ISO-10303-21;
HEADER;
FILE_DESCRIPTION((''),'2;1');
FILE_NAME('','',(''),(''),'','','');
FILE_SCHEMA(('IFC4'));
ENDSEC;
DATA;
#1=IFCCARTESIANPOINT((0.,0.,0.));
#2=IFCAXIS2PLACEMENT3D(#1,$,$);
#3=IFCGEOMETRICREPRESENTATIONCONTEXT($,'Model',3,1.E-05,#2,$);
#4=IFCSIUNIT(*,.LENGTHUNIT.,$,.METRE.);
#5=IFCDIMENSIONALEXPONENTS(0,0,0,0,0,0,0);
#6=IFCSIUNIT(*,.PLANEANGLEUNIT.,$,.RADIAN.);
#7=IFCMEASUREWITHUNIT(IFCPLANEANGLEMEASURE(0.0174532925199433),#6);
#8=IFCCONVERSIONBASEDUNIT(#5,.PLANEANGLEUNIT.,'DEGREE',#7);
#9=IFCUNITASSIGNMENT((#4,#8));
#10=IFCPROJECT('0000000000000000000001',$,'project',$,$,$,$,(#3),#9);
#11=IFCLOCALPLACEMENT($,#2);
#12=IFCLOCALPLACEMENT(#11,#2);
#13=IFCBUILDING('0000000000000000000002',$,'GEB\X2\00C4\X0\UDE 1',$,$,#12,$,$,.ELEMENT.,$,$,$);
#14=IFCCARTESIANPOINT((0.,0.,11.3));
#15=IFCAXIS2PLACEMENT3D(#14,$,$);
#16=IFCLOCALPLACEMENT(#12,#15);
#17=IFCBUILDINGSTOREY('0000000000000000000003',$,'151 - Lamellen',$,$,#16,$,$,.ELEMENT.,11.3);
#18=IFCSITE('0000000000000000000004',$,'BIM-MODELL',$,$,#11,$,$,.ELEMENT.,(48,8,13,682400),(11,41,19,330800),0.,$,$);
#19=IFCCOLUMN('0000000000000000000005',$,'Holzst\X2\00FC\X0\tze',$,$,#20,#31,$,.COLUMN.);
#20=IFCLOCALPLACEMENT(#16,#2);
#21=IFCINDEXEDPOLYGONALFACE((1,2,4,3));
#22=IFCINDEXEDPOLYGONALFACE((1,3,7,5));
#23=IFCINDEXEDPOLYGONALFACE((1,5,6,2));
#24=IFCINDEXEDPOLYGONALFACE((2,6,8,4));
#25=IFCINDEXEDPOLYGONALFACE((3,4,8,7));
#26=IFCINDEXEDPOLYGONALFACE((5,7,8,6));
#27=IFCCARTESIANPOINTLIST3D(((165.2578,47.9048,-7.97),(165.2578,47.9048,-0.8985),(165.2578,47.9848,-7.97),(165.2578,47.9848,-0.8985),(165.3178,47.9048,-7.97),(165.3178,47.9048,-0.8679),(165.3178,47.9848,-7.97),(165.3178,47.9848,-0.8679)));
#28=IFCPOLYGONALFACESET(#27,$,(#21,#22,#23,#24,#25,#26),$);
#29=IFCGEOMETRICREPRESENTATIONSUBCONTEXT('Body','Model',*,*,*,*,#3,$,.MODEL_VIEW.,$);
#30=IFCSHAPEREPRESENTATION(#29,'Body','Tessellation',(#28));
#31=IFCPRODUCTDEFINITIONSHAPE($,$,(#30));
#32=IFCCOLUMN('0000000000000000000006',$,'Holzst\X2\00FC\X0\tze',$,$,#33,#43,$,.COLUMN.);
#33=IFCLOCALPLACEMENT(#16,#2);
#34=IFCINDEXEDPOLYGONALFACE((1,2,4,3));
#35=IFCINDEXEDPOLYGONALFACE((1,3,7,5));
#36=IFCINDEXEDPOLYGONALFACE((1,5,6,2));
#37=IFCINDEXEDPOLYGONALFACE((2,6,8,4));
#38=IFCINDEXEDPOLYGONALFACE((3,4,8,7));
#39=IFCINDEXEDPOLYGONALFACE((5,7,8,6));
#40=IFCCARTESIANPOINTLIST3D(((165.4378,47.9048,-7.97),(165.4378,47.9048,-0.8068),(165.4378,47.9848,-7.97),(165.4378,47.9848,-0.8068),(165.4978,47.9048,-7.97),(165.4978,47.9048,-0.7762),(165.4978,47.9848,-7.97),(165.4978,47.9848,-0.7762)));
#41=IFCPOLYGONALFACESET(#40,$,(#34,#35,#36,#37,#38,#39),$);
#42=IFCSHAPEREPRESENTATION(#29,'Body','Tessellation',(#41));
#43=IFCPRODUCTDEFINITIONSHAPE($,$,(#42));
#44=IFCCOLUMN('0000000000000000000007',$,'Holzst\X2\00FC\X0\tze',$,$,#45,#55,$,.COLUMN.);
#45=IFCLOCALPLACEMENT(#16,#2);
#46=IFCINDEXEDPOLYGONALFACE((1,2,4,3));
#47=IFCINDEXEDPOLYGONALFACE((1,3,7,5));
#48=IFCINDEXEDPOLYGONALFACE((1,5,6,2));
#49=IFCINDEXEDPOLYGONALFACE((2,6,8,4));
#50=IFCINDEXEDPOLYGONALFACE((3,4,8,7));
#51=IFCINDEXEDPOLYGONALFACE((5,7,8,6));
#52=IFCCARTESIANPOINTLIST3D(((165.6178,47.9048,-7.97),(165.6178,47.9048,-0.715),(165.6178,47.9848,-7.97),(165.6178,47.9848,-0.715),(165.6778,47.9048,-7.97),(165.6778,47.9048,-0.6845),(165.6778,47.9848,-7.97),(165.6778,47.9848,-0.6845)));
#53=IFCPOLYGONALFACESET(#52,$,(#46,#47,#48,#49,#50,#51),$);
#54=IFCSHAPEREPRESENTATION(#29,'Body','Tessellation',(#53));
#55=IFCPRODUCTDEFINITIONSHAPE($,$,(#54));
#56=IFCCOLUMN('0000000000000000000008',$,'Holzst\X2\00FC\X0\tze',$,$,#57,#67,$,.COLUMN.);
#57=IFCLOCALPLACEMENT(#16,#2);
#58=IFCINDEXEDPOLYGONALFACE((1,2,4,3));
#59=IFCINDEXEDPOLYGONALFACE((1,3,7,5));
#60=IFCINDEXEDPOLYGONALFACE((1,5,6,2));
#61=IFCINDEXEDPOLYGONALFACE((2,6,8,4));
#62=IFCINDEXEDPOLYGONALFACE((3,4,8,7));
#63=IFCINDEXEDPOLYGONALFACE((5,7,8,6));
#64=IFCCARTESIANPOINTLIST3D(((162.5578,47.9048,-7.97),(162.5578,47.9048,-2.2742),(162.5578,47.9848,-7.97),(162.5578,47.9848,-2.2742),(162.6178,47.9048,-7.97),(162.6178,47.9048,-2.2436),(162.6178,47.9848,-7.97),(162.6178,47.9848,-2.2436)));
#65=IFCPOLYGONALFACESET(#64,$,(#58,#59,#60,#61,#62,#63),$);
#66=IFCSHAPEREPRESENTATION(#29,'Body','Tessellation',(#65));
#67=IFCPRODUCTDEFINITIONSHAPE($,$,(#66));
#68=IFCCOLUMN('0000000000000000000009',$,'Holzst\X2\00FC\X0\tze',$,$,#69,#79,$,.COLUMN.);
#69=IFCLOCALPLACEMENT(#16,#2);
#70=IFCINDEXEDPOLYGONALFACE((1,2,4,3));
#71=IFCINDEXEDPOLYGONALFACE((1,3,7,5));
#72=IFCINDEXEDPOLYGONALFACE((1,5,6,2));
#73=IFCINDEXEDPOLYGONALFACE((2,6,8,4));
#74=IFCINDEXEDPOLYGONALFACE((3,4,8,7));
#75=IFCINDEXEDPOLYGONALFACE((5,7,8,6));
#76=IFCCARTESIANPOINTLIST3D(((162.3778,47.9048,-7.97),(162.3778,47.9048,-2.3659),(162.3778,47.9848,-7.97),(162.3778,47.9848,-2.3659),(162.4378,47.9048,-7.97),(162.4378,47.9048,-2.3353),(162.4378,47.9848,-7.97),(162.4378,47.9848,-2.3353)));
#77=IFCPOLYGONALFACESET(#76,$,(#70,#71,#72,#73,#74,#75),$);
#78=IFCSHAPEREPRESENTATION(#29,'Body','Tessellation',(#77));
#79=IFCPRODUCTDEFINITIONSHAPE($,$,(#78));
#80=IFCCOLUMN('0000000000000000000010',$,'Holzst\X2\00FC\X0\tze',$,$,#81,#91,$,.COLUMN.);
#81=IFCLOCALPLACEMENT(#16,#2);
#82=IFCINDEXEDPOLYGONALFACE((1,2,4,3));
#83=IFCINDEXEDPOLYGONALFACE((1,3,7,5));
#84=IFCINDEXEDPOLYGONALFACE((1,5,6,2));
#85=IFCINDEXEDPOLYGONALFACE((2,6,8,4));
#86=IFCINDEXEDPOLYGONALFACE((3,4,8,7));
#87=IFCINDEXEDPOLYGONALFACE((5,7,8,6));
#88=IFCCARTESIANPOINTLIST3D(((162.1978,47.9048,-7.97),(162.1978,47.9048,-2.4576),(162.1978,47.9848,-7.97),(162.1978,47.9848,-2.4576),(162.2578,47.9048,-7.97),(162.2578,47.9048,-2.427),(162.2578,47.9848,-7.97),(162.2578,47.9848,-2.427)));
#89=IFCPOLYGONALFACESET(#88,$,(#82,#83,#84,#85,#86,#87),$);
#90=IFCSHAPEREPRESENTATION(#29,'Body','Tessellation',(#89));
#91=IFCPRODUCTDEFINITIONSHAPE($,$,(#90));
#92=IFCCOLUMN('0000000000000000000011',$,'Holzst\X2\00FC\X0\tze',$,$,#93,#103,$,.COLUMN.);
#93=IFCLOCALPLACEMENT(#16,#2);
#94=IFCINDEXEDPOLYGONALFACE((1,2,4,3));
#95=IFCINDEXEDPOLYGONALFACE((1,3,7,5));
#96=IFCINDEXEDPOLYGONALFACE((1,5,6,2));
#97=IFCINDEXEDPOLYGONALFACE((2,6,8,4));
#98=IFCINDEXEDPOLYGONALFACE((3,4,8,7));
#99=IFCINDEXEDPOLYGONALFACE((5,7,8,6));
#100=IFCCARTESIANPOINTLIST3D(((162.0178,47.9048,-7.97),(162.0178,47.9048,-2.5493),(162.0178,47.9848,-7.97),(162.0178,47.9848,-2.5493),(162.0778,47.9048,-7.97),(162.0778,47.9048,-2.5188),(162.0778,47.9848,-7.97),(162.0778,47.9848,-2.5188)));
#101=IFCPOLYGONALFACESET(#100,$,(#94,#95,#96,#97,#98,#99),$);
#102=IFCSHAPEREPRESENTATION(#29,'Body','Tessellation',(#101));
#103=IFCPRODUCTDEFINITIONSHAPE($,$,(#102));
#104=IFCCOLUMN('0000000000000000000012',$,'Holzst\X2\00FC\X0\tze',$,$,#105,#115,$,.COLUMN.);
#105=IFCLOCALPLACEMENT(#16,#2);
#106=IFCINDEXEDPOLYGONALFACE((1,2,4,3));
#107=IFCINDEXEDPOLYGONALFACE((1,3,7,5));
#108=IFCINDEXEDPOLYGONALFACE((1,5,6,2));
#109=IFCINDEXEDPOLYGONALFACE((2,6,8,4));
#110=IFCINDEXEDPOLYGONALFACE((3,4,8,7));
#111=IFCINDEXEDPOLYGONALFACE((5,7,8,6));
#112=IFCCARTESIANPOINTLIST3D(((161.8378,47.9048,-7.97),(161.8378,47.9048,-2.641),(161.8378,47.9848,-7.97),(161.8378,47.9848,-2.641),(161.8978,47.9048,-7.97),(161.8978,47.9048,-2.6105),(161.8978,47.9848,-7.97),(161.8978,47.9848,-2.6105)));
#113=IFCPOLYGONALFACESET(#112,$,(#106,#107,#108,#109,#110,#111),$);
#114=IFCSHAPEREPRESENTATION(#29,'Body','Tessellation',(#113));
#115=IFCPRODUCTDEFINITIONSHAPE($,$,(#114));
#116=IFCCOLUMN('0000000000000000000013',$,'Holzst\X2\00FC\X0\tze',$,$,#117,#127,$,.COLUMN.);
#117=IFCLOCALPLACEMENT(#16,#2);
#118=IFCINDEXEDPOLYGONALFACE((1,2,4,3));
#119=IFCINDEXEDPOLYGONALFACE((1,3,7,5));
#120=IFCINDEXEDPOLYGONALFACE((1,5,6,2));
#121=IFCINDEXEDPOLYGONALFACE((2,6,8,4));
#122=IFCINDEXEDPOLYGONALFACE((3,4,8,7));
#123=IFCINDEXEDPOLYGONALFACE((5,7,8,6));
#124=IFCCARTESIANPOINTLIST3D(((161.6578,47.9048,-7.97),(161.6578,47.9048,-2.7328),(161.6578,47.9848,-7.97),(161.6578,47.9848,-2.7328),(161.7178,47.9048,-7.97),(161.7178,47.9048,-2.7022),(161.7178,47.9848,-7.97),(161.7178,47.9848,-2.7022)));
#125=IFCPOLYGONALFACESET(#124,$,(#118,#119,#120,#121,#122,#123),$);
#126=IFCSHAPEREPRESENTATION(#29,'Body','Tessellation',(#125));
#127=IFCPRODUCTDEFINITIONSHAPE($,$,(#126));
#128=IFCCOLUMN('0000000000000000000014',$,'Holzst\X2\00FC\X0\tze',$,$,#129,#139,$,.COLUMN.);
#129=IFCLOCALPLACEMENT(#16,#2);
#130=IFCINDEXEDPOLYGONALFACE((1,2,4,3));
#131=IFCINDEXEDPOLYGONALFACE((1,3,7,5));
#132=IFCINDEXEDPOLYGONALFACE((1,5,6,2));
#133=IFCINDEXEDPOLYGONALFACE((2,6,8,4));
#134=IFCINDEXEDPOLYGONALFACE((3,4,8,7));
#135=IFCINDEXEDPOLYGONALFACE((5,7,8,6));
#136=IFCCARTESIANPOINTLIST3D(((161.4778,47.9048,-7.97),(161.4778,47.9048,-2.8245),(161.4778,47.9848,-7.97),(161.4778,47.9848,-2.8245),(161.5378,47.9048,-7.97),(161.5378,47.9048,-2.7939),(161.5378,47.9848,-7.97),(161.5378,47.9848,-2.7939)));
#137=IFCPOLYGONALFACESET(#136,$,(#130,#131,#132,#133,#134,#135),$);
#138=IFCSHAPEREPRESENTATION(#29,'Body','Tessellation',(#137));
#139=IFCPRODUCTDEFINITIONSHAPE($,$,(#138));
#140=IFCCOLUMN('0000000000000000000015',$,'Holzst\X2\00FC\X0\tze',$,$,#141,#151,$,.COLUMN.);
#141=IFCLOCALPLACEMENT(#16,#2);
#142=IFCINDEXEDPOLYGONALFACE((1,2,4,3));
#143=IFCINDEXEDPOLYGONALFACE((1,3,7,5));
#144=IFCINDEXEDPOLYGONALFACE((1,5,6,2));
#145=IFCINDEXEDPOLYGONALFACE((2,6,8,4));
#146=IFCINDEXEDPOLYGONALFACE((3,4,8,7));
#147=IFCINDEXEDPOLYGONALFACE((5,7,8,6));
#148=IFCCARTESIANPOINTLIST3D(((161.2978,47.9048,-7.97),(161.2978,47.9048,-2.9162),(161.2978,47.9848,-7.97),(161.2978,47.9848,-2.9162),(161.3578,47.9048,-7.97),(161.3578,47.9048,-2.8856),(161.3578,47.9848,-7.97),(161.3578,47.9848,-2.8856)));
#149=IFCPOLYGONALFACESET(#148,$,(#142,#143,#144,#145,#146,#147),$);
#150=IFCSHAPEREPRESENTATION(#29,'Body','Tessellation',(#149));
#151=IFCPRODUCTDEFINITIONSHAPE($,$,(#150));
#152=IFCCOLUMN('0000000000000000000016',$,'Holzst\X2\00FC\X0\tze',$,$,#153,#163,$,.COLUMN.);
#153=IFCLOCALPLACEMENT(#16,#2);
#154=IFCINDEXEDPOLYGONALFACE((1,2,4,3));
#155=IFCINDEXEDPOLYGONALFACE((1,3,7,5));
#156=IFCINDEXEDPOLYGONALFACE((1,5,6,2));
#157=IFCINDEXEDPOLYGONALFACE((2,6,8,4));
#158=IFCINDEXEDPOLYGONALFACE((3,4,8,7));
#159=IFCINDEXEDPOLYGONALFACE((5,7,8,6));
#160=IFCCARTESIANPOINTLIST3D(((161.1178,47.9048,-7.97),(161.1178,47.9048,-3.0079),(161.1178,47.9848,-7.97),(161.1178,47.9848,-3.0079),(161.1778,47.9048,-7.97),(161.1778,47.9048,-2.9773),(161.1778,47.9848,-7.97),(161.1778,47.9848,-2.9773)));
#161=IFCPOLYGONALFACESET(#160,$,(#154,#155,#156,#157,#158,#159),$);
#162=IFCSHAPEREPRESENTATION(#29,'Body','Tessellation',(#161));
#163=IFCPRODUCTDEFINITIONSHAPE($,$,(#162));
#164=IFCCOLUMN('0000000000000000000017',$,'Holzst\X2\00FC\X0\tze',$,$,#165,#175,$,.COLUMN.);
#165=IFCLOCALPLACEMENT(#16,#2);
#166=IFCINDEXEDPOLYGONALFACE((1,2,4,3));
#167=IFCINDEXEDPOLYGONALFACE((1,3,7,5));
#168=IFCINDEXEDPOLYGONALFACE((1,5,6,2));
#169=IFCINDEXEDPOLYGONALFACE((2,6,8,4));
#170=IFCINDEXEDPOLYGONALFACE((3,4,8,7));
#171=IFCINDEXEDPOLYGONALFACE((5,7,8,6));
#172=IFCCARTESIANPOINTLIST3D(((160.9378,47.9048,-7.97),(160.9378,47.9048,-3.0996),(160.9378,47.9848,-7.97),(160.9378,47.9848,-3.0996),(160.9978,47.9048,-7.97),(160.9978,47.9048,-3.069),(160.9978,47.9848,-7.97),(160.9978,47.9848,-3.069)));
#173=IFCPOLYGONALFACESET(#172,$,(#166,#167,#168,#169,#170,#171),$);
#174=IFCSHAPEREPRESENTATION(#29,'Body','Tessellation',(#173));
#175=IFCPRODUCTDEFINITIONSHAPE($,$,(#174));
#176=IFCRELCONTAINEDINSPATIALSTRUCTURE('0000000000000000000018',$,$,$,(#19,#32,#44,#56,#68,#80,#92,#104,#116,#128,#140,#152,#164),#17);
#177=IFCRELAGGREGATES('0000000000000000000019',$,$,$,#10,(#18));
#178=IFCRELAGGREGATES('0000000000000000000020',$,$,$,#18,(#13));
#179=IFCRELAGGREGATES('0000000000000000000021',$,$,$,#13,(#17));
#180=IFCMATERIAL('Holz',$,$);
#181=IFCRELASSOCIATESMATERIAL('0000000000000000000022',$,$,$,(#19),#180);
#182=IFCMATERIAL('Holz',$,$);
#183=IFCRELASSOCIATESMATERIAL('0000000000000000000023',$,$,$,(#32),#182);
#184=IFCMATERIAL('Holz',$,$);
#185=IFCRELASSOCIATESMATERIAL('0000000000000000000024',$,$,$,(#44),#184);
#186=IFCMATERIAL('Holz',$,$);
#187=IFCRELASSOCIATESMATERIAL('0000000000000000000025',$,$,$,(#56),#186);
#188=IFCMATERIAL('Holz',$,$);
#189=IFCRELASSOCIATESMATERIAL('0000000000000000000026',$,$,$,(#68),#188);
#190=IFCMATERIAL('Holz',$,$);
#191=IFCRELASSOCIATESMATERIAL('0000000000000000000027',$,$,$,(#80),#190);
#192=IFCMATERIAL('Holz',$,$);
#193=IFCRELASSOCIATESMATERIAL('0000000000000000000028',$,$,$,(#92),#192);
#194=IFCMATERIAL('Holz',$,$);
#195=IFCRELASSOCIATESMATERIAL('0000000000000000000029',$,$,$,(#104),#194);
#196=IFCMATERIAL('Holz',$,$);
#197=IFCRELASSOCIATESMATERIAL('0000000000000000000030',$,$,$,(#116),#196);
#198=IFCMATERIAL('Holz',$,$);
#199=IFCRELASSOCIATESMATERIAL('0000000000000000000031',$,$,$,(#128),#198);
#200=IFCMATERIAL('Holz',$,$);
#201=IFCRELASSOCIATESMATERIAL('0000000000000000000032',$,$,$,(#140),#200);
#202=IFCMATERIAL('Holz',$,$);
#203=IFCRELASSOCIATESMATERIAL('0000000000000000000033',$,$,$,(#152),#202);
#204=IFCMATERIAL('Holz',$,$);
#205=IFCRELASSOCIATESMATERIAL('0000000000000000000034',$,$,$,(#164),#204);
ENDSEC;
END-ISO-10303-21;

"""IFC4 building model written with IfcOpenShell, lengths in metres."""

from ifc_helpers import new_model, entity, si_unit, converted_unit, frame, frame_2d, origin, origin_with_axes, place, context, subcontext, project, spatial, rectangle, extrude, clip, halfspace, material, element, save


model = new_model("IFC4")

# Units and contexts
model_context = context("Model", 3, precision=1e-05, world=origin())
body_context = subcontext(model_context, "Body", "Model", "MODEL_VIEW")
ifc_project = project(units=[si_unit("LENGTHUNIT", "METRE"), converted_unit("PLANEANGLEUNIT", "DEGREE", entity("IfcPlaneAngleMeasure", 0.0174532925199433), si_unit("PLANEANGLEUNIT", "RADIAN"), dimensions=[0, 0, 0, 0, 0, 0, 0])], contexts=[model_context])

# Site, building, storey
site_placement = place(None, origin())
site = spatial("IfcSite", under=ifc_project, at=site_placement, Name="BIM-MODELL", CompositionType="ELEMENT", RefLatitude=(48, 8, 13, 682400), RefLongitude=(11, 41, 19, 330800), RefElevation=0.0)
building_placement = place(site_placement, origin())
building = spatial("IfcBuilding", under=site, at=building_placement, Name="GEBÄUDE 1", CompositionType="ELEMENT")
storey_placement = place(building_placement, frame((0.0, 0.0, 11.3)))
storey = spatial("IfcBuildingStorey", under=building, at=storey_placement, Name="151 - Lamellen", CompositionType="ELEMENT", Elevation=11.3)

# Columns
ifc_material_1 = material(Name="Holz")
column_1_placement = place(storey_placement, frame((165.2578, 47.9048, -7.97)))
element("IfcColumn", 1, at=column_1_placement, inside=storey, material=ifc_material_1, Name="Holzstütze", PredefinedType="COLUMN", context=body_context, shape_type="Clipping", body=[
    clip(extrude(rectangle(XDim=0.06, YDim=0.08, at=frame_2d((0.03, 0.04), x_axis=(1.0, 0.0))), origin_with_axes(), (0.0, 0.0, 1.0), 7.1021), halfspace(frame((0.03, 0.04, 7.0868), z_axis=(0.45399, 0.0, -0.891007), x_axis=(0.0, 1.0, 0.0)), True)),
])
ifc_material_2 = material(Name="Holz")
column_2_placement = place(storey_placement, frame((165.4378, 47.9048, -7.97)))
element("IfcColumn", 2, at=column_2_placement, inside=storey, material=ifc_material_2, Name="Holzstütze", PredefinedType="COLUMN", context=body_context, shape_type="Clipping", body=[
    clip(extrude(rectangle(XDim=0.06, YDim=0.08, at=frame_2d((0.03, 0.04), x_axis=(1.0, 0.0))), origin_with_axes(), (0.0, 0.0, 1.0), 7.1938), halfspace(frame((0.03, 0.04, 7.1785), z_axis=(0.45399, 0.0, -0.891007), x_axis=(0.0, 1.0, 0.0)), True)),
])
ifc_material_3 = material(Name="Holz")
column_3_placement = place(storey_placement, frame((165.6178, 47.9048, -7.97)))
element("IfcColumn", 3, at=column_3_placement, inside=storey, material=ifc_material_3, Name="Holzstütze", PredefinedType="COLUMN", context=body_context, shape_type="Clipping", body=[
    clip(extrude(rectangle(XDim=0.06, YDim=0.08, at=frame_2d((0.03, 0.04), x_axis=(1.0, 0.0))), origin_with_axes(), (0.0, 0.0, 1.0), 7.2855), halfspace(frame((0.03, 0.04, 7.2702), z_axis=(0.45399, 0.0, -0.891007), x_axis=(0.0, 1.0, 0.0)), True)),
])
ifc_material_4 = material(Name="Holz")
column_4_placement = place(storey_placement, frame((162.5578, 47.9048, -7.97)))
element("IfcColumn", 4, at=column_4_placement, inside=storey, material=ifc_material_4, Name="Holzstütze", PredefinedType="COLUMN", context=body_context, shape_type="Clipping", body=[
    clip(extrude(rectangle(XDim=0.06, YDim=0.08, at=frame_2d((0.03, 0.04), x_axis=(1.0, 0.0))), origin_with_axes(), (0.0, 0.0, 1.0), 5.7264), halfspace(frame((0.03, 0.04, 5.7111), z_axis=(0.45399, 0.0, -0.891007), x_axis=(0.0, 1.0, 0.0)), True)),
])
ifc_material_5 = material(Name="Holz")
column_5_placement = place(storey_placement, frame((162.3778, 47.9048, -7.97)))
element("IfcColumn", 5, at=column_5_placement, inside=storey, material=ifc_material_5, Name="Holzstütze", PredefinedType="COLUMN", context=body_context, shape_type="Clipping", body=[
    clip(extrude(rectangle(XDim=0.06, YDim=0.08, at=frame_2d((0.03, 0.04), x_axis=(1.0, 0.0))), origin_with_axes(), (0.0, 0.0, 1.0), 5.6347), halfspace(frame((0.03, 0.04, 5.6194), z_axis=(0.45399, 0.0, -0.891007), x_axis=(0.0, 1.0, 0.0)), True)),
])
ifc_material_6 = material(Name="Holz")
column_6_placement = place(storey_placement, frame((162.1978, 47.9048, -7.97)))
element("IfcColumn", 6, at=column_6_placement, inside=storey, material=ifc_material_6, Name="Holzstütze", PredefinedType="COLUMN", context=body_context, shape_type="Clipping", body=[
    clip(extrude(rectangle(XDim=0.06, YDim=0.08, at=frame_2d((0.03, 0.04), x_axis=(1.0, 0.0))), origin_with_axes(), (0.0, 0.0, 1.0), 5.543), halfspace(frame((0.03, 0.04, 5.5277), z_axis=(0.45399, 0.0, -0.891007), x_axis=(0.0, 1.0, 0.0)), True)),
])
ifc_material_7 = material(Name="Holz")
column_7_placement = place(storey_placement, frame((162.0178, 47.9048, -7.97)))
element("IfcColumn", 7, at=column_7_placement, inside=storey, material=ifc_material_7, Name="Holzstütze", PredefinedType="COLUMN", context=body_context, shape_type="Clipping", body=[
    clip(extrude(rectangle(XDim=0.06, YDim=0.08, at=frame_2d((0.03, 0.04), x_axis=(1.0, 0.0))), origin_with_axes(), (0.0, 0.0, 1.0), 5.4512), halfspace(frame((0.03, 0.04, 5.436), z_axis=(0.45399, 0.0, -0.891007), x_axis=(0.0, 1.0, 0.0)), True)),
])
ifc_material_8 = material(Name="Holz")
column_8_placement = place(storey_placement, frame((161.8378, 47.9048, -7.97)))
element("IfcColumn", 8, at=column_8_placement, inside=storey, material=ifc_material_8, Name="Holzstütze", PredefinedType="COLUMN", context=body_context, shape_type="Clipping", body=[
    clip(extrude(rectangle(XDim=0.06, YDim=0.08, at=frame_2d((0.03, 0.04), x_axis=(1.0, 0.0))), origin_with_axes(), (0.0, 0.0, 1.0), 5.3595), halfspace(frame((0.03, 0.04, 5.3442), z_axis=(0.45399, 0.0, -0.891007), x_axis=(0.0, 1.0, 0.0)), True)),
])
ifc_material_9 = material(Name="Holz")
column_9_placement = place(storey_placement, frame((161.6578, 47.9048, -7.97)))
element("IfcColumn", 9, at=column_9_placement, inside=storey, material=ifc_material_9, Name="Holzstütze", PredefinedType="COLUMN", context=body_context, shape_type="Clipping", body=[
    clip(extrude(rectangle(XDim=0.06, YDim=0.08, at=frame_2d((0.03, 0.04), x_axis=(1.0, 0.0))), origin_with_axes(), (0.0, 0.0, 1.0), 5.2678), halfspace(frame((0.03, 0.04, 5.2525), z_axis=(0.45399, 0.0, -0.891007), x_axis=(0.0, 1.0, 0.0)), True)),
])
ifc_material_10 = material(Name="Holz")
column_10_placement = place(storey_placement, frame((161.4778, 47.9048, -7.97)))
element("IfcColumn", 10, at=column_10_placement, inside=storey, material=ifc_material_10, Name="Holzstütze", PredefinedType="COLUMN", context=body_context, shape_type="Clipping", body=[
    clip(extrude(rectangle(XDim=0.06, YDim=0.08, at=frame_2d((0.03, 0.04), x_axis=(1.0, 0.0))), origin_with_axes(), (0.0, 0.0, 1.0), 5.1761), halfspace(frame((0.03, 0.04, 5.1608), z_axis=(0.45399, 0.0, -0.891007), x_axis=(0.0, 1.0, 0.0)), True)),
])
ifc_material_11 = material(Name="Holz")
column_11_placement = place(storey_placement, frame((161.2978, 47.9048, -7.97)))
element("IfcColumn", 11, at=column_11_placement, inside=storey, material=ifc_material_11, Name="Holzstütze", PredefinedType="COLUMN", context=body_context, shape_type="Clipping", body=[
    clip(extrude(rectangle(XDim=0.06, YDim=0.08, at=frame_2d((0.03, 0.04), x_axis=(1.0, 0.0))), origin_with_axes(), (0.0, 0.0, 1.0), 5.0844), halfspace(frame((0.03, 0.04, 5.0691), z_axis=(0.45399, 0.0, -0.891007), x_axis=(0.0, 1.0, 0.0)), True)),
])
ifc_material_12 = material(Name="Holz")
column_12_placement = place(storey_placement, frame((161.1178, 47.9048, -7.97)))
element("IfcColumn", 12, at=column_12_placement, inside=storey, material=ifc_material_12, Name="Holzstütze", PredefinedType="COLUMN", context=body_context, shape_type="Clipping", body=[
    clip(extrude(rectangle(XDim=0.06, YDim=0.08, at=frame_2d((0.03, 0.04), x_axis=(1.0, 0.0))), origin_with_axes(), (0.0, 0.0, 1.0), 4.9927), halfspace(frame((0.03, 0.04, 4.9774), z_axis=(0.45399, 0.0, -0.891007), x_axis=(0.0, 1.0, 0.0)), True)),
])
ifc_material_13 = material(Name="Holz")
column_13_placement = place(storey_placement, frame((160.9378, 47.9048, -7.97)))
element("IfcColumn", 13, at=column_13_placement, inside=storey, material=ifc_material_13, Name="Holzstütze", PredefinedType="COLUMN", context=body_context, shape_type="Clipping", body=[
    clip(extrude(rectangle(XDim=0.06, YDim=0.08, at=frame_2d((0.03, 0.04), x_axis=(1.0, 0.0))), origin_with_axes(), (0.0, 0.0, 1.0), 4.901), halfspace(frame((0.03, 0.04, 4.8857), z_axis=(0.45399, 0.0, -0.891007), x_axis=(0.0, 1.0, 0.0)), True)),
])

save(model, "model.ifc")
